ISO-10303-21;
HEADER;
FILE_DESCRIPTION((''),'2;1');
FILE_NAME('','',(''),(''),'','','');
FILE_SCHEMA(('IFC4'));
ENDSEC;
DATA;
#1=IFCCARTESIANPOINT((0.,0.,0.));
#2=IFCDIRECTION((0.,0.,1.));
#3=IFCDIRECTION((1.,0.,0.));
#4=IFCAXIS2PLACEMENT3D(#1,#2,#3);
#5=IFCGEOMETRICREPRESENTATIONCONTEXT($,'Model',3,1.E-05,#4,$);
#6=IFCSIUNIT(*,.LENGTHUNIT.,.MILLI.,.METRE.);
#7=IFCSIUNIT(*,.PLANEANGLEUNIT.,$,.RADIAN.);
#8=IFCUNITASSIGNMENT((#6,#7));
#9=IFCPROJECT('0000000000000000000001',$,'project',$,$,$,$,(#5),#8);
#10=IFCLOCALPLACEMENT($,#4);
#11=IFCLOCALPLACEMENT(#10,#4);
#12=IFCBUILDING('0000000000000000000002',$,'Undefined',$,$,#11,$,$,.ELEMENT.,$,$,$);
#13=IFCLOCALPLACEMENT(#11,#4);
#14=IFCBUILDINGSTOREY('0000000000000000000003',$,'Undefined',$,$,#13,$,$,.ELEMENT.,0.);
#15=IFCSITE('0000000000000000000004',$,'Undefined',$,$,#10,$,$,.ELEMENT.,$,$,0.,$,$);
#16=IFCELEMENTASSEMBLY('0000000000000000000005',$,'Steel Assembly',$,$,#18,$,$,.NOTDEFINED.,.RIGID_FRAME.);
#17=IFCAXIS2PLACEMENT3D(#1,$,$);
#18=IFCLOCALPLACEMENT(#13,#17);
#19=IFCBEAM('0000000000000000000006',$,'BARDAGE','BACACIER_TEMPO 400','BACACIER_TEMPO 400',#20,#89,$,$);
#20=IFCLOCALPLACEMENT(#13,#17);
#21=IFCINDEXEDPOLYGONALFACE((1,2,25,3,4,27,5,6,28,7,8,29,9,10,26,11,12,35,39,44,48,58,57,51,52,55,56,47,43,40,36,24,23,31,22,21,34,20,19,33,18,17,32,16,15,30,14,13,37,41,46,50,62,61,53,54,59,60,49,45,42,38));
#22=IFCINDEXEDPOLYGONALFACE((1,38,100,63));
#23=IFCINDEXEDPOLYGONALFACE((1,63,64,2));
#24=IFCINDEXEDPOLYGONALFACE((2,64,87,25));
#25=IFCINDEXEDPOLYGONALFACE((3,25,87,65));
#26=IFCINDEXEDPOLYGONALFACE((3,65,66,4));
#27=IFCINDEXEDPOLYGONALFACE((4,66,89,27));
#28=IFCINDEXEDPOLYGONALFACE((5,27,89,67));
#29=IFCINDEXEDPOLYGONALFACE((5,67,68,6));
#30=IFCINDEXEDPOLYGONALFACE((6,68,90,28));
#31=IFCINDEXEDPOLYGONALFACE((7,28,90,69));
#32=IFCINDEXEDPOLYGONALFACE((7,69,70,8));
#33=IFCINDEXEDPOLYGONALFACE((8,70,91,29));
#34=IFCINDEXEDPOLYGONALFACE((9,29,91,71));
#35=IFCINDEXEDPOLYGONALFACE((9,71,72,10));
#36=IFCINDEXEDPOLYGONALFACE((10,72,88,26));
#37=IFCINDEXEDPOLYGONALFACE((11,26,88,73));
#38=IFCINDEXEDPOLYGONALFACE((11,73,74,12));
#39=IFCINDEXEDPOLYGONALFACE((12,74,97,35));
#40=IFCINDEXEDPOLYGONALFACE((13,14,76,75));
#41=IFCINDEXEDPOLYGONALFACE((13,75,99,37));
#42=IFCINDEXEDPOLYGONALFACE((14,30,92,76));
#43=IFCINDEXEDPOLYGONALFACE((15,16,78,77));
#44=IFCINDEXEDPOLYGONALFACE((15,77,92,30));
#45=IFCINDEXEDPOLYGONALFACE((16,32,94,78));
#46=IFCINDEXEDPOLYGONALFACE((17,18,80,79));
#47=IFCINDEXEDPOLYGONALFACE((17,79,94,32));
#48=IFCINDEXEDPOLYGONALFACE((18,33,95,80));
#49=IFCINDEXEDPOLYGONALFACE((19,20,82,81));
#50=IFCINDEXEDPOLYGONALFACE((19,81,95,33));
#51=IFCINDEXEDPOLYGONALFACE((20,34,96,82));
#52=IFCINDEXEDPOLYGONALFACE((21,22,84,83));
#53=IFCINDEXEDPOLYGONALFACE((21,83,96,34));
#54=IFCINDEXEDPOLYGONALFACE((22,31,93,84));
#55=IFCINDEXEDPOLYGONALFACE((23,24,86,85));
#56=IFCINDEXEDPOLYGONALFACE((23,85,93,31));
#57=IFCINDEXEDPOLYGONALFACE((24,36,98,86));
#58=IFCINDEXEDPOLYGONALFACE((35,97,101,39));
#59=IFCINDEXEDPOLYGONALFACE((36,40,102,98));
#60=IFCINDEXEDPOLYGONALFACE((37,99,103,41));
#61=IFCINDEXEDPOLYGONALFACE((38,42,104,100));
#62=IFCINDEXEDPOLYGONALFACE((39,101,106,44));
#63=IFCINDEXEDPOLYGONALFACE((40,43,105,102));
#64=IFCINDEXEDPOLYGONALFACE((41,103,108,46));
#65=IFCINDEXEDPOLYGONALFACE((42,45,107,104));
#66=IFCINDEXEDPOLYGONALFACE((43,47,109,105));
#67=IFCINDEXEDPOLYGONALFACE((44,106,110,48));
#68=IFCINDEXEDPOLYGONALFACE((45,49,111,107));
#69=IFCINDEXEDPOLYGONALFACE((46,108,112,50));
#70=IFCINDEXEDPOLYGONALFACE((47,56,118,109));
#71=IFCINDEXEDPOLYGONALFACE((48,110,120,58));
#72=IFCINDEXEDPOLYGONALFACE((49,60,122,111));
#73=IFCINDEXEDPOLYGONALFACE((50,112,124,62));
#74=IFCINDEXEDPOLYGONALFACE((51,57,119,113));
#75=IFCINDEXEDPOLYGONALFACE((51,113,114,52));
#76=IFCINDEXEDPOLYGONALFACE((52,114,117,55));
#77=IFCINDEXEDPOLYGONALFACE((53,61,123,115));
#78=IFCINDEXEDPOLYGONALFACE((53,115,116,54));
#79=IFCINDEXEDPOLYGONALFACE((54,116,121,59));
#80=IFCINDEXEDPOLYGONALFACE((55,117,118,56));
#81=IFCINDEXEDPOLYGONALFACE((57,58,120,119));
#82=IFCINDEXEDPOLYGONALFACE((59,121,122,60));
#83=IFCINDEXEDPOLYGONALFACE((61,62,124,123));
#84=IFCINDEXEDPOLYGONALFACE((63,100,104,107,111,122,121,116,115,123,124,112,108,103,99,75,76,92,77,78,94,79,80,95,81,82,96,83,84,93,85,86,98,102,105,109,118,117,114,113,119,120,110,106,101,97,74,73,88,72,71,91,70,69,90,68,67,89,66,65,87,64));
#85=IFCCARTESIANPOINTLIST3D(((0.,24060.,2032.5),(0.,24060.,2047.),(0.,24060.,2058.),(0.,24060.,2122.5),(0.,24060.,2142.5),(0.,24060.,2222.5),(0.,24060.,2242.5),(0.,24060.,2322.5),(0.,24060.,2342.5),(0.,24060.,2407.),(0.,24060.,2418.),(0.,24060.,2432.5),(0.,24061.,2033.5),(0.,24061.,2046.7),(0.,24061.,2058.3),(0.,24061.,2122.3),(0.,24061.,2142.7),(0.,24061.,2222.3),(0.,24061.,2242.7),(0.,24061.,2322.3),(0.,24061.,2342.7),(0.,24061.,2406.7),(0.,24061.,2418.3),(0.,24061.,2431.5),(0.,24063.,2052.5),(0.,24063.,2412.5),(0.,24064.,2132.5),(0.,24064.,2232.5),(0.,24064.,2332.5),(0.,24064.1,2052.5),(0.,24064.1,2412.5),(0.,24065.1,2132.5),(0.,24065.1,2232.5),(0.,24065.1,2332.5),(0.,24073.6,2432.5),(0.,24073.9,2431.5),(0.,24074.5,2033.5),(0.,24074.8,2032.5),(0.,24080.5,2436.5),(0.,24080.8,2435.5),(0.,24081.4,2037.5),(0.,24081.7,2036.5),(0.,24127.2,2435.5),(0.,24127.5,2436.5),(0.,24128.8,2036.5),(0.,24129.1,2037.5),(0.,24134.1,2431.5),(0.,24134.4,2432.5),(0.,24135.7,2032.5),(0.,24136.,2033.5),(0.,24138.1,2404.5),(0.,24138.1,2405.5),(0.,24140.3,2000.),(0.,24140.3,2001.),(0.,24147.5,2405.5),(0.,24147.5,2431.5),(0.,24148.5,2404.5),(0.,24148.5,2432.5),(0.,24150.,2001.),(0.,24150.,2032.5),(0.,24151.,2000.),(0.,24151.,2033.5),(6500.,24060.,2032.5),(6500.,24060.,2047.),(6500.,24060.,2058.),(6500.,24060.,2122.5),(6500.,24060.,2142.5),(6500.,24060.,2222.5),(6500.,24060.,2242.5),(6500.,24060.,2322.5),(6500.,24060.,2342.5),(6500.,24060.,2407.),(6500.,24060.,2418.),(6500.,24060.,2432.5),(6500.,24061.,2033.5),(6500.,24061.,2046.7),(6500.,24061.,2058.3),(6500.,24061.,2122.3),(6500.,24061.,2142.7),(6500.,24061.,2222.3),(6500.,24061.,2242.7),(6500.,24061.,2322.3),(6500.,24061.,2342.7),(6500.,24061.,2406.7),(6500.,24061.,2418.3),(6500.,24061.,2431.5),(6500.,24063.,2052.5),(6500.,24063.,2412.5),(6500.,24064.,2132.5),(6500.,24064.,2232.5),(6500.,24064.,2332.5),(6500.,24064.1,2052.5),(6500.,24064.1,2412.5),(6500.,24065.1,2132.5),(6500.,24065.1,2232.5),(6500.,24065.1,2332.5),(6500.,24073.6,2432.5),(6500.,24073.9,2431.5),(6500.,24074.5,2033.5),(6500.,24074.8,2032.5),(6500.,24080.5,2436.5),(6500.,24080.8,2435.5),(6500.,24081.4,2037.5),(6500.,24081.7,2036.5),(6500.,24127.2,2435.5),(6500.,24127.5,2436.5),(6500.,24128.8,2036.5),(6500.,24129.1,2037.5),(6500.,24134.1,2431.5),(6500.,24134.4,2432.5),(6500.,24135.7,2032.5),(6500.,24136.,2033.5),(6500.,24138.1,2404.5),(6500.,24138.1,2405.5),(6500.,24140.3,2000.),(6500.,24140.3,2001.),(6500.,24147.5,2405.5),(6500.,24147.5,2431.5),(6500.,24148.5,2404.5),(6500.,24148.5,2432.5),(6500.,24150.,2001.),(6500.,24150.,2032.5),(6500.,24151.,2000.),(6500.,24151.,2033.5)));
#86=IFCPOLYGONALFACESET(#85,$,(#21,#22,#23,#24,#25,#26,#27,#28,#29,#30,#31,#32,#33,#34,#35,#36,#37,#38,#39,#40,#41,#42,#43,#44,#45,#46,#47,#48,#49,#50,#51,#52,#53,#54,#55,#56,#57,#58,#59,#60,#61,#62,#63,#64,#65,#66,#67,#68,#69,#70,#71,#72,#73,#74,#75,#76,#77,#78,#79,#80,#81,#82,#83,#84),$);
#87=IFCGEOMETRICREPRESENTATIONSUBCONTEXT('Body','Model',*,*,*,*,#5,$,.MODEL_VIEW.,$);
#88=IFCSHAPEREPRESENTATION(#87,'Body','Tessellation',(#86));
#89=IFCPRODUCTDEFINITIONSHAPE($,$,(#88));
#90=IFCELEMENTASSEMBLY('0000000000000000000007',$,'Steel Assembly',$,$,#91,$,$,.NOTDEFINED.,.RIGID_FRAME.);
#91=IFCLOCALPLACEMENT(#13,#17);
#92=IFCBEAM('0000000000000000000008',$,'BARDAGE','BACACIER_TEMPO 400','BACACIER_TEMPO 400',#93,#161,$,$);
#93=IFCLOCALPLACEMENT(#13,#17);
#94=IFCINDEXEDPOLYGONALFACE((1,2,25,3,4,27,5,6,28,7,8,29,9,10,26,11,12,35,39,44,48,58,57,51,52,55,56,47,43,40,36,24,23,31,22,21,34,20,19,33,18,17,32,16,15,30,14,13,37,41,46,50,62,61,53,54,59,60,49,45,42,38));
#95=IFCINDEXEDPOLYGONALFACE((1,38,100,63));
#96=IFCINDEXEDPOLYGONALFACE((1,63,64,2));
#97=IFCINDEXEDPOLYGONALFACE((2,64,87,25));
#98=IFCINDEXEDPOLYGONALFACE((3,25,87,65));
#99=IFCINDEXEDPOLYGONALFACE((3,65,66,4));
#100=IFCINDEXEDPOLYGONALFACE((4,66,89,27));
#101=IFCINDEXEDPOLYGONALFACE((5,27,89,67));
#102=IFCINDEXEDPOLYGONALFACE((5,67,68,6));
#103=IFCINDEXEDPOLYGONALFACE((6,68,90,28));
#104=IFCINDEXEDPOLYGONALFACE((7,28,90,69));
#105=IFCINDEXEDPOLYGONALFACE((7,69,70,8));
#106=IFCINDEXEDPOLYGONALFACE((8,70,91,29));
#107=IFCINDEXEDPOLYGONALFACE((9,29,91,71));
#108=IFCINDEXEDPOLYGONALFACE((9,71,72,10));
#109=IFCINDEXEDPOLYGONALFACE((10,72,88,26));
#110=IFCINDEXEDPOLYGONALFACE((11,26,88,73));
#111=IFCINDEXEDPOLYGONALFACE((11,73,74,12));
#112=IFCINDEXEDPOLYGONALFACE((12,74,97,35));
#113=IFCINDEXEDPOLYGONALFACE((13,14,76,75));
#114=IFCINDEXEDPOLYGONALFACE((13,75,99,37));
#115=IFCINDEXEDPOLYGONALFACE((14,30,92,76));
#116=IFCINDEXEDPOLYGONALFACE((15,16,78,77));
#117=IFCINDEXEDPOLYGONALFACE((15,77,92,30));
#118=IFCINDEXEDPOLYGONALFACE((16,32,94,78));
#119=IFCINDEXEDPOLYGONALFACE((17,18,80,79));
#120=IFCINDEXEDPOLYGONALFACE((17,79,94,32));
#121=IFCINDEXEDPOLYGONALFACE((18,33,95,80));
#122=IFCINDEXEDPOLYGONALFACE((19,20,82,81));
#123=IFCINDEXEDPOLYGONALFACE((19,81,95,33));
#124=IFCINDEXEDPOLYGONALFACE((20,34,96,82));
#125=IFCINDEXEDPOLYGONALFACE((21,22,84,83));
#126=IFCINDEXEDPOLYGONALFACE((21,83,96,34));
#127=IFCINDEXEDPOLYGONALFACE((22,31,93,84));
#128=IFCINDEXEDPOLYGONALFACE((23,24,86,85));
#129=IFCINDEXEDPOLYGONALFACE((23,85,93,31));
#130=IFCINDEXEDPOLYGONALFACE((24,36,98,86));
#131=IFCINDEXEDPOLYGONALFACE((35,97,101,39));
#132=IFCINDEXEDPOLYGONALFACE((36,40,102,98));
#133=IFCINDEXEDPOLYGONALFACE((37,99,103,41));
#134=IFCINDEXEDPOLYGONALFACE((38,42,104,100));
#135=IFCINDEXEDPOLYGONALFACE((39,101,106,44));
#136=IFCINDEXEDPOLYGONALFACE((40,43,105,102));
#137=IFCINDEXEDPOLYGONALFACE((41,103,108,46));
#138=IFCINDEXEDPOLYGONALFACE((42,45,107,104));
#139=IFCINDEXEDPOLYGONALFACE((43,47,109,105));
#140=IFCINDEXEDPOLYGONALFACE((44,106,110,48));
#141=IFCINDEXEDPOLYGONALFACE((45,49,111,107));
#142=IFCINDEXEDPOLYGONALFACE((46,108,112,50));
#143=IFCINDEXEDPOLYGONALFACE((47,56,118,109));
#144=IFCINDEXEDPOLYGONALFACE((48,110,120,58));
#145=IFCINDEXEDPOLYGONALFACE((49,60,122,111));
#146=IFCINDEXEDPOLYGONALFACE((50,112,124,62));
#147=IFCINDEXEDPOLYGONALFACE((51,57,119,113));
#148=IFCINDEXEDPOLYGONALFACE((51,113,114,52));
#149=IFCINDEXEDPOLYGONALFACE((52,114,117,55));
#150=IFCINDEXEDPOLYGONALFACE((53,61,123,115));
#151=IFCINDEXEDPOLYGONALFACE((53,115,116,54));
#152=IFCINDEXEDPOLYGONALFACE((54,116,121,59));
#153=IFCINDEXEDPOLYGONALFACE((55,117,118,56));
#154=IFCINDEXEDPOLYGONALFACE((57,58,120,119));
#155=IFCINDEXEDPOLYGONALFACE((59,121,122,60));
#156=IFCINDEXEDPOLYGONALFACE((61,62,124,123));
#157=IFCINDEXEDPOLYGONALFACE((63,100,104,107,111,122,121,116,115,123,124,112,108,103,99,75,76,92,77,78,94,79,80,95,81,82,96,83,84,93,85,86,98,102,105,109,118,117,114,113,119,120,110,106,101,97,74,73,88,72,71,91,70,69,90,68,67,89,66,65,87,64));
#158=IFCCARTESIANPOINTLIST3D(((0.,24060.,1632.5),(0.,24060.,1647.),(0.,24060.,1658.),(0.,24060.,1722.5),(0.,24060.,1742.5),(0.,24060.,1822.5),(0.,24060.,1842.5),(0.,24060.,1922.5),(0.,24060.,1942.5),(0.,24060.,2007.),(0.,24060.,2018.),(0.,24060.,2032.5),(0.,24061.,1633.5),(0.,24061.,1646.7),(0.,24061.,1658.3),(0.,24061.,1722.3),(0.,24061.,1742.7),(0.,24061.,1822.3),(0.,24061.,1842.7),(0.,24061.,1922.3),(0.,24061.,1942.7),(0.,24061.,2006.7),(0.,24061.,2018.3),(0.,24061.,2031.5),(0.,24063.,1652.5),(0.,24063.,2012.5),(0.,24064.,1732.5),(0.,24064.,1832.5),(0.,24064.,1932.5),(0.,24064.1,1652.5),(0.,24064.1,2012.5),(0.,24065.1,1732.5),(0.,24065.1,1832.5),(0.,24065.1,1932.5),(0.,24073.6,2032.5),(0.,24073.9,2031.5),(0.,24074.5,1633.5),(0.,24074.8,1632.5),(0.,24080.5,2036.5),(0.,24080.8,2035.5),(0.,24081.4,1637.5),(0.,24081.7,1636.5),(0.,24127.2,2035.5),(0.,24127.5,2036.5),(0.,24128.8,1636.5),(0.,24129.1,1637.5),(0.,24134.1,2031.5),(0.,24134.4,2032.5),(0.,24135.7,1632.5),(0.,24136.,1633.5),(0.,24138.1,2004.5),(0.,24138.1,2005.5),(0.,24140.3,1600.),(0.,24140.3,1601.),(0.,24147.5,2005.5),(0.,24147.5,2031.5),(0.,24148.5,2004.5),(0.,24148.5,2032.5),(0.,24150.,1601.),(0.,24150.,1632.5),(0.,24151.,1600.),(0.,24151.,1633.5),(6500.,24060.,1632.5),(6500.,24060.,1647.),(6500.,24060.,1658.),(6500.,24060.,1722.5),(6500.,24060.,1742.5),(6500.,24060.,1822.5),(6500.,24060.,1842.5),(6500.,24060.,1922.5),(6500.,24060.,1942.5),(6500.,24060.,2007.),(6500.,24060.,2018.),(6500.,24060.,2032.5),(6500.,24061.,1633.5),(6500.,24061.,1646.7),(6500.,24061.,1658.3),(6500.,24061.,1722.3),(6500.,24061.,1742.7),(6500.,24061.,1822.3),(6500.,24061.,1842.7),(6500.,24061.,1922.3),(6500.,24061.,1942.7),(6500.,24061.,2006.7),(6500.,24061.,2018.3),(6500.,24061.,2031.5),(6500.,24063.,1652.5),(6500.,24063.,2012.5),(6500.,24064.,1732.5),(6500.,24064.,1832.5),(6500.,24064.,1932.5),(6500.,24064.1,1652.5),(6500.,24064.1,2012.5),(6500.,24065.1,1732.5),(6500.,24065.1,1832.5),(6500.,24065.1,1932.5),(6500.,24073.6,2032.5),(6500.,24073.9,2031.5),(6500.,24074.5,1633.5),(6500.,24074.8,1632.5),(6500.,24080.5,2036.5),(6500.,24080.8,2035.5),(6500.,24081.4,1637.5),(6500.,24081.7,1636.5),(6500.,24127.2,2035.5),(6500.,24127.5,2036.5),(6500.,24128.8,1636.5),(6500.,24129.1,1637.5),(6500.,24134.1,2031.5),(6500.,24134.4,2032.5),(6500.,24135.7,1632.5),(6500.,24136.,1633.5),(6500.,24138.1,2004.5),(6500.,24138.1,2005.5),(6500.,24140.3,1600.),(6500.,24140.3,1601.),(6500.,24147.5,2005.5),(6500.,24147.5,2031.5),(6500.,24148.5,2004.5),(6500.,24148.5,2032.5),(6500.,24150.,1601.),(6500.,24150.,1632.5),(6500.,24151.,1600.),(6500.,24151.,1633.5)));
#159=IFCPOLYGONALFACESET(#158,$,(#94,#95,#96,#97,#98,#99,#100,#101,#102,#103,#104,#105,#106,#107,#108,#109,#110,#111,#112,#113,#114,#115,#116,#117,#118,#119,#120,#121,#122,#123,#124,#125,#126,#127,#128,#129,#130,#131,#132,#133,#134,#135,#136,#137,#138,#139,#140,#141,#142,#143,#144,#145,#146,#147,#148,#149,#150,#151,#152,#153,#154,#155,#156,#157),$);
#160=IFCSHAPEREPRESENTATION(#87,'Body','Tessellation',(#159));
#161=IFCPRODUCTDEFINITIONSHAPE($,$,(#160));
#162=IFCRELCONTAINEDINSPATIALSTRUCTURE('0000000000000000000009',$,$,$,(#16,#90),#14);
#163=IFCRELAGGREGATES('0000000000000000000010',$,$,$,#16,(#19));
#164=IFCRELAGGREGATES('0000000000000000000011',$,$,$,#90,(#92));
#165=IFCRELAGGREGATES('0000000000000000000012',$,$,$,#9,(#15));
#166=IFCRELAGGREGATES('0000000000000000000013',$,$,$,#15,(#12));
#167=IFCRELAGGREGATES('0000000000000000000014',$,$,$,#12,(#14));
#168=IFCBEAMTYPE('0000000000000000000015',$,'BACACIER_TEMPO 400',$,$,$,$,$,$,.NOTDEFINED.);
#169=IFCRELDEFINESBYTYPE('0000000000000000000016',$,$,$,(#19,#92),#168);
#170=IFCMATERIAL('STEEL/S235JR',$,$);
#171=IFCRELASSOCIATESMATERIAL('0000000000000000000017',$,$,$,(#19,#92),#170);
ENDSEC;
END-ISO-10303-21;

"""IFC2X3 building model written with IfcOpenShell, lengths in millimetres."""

from ifc_helpers import new_model, si_unit, frame, origin_with_axes, place, context, subcontext, project, spatial, polyline, outline, extrude, material, type_object, element, aggregate, save


model = new_model("IFC2X3")

# Units and contexts
model_context = context("Model", 3, precision=1e-05, world=origin_with_axes())
body_context = subcontext(model_context, "Body", "Model", "MODEL_VIEW")
ifc_project = project(units=[si_unit("LENGTHUNIT", "METRE", prefix="MILLI"), si_unit("PLANEANGLEUNIT", "RADIAN")], contexts=[model_context])

# Site, building, storey
site_placement = place(None, origin_with_axes())
site = spatial("IfcSite", under=ifc_project, at=site_placement, Name="Undefined", CompositionType="ELEMENT", RefElevation=0.0)
building_placement = place(site_placement, origin_with_axes())
building = spatial("IfcBuilding", under=site, at=building_placement, Name="Undefined", CompositionType="ELEMENT")
storey_placement = place(building_placement, origin_with_axes())
storey = spatial("IfcBuildingStorey", under=building, at=storey_placement, Name="Undefined", CompositionType="ELEMENT", Elevation=0.0)

# Element assemblies, beams
ifc_material_1 = material(Name="STEEL/S235JR")
beam_type_1 = type_object("IfcBeamType", Name="BACACIER_TEMPO 400", PredefinedType="NOTDEFINED")
assembly_1_placement = place(storey_placement, origin_with_axes())
assembly_1 = element("IfcElementAssembly", 1, at=assembly_1_placement, inside=storey, Name="Steel Assembly", AssemblyPlace="NOTDEFINED", PredefinedType="RIGID_FRAME")
beam_1_placement = place(assembly_1_placement, frame((0.0, 24105.5, 2218.2), z_axis=(0.0, 1.0, 0.0), x_axis=(1.0, 0.0, 0.0)))
beam_1 = element("IfcBeam", 2, at=beam_1_placement, type_object=beam_type_1, material=ifc_material_1, Name="BARDAGE", Description="BACACIER_TEMPO 400", ObjectType="BACACIER_TEMPO 400", context=body_context, shape_type="SweptSolid", body=[
    extrude(outline(polyline([(218.2, -25.0), (214.2, -31.9), (214.2, -45.5), (199.8, -45.5), (194.2, -42.5), (188.8, -45.5), (124.2, -45.5), (114.2, -41.5), (104.2, -45.5), (24.2, -45.5), (14.2, -41.5), (4.2, -45.5), (-75.8, -45.5), (-85.8, -41.5), (-95.8, -45.5), (-160.2, -45.5), (-165.8, -42.5), (-171.2, -45.5), (-185.8, -45.5), (-185.8, -30.7), (-181.8, -23.8), (-181.8, 23.3), (-185.8, 30.2), (-185.8, 44.5), (-217.2, 44.5), (-217.2, 34.8), (-218.2, 34.8), (-218.2, 45.5), (-184.8, 45.5), (-184.8, 30.5), (-180.8, 23.6), (-180.8, -24.1), (-184.8, -31.0), (-184.8, -44.5), (-171.5, -44.5), (-165.8, -41.4), (-160.0, -44.5), (-95.9, -44.5), (-85.8, -40.4), (-75.6, -44.5), (4.1, -44.5), (14.2, -40.4), (24.4, -44.5), (104.1, -44.5), (114.2, -40.4), (124.4, -44.5), (188.5, -44.5), (194.2, -41.4), (200.0, -44.5), (213.2, -44.5), (213.2, -31.6), (217.2, -24.7), (217.2, 21.7), (213.2, 28.6), (213.2, 42.0), (187.2, 42.0), (187.2, 32.5), (186.2, 32.5), (186.2, 43.0), (214.2, 43.0), (214.2, 28.9), (218.2, 22.0), (218.2, -25.0)])), frame((6500.0, 0.0, 0.0), z_axis=(-1.0, 0.0, 0.0), x_axis=(0.0, -1.0, 0.0)), (0.0, 0.0, 1.0), 6500.0),
])
aggregate(assembly_1, [beam_1])
assembly_2_placement = place(storey_placement, origin_with_axes())
assembly_2 = element("IfcElementAssembly", 3, at=assembly_2_placement, inside=storey, Name="Steel Assembly", AssemblyPlace="NOTDEFINED", PredefinedType="RIGID_FRAME")
beam_2_placement = place(assembly_2_placement, frame((0.0, 24105.5, 1818.2), z_axis=(0.0, 1.0, 0.0), x_axis=(1.0, 0.0, 0.0)))
beam_2 = element("IfcBeam", 4, at=beam_2_placement, type_object=beam_type_1, material=ifc_material_1, Name="BARDAGE", Description="BACACIER_TEMPO 400", ObjectType="BACACIER_TEMPO 400", context=body_context, shape_type="SweptSolid", body=[
    extrude(outline(polyline([(218.2, -25.0), (214.2, -31.9), (214.2, -45.5), (199.8, -45.5), (194.2, -42.5), (188.8, -45.5), (124.2, -45.5), (114.2, -41.5), (104.2, -45.5), (24.2, -45.5), (14.2, -41.5), (4.2, -45.5), (-75.8, -45.5), (-85.8, -41.5), (-95.8, -45.5), (-160.2, -45.5), (-165.8, -42.5), (-171.2, -45.5), (-185.8, -45.5), (-185.8, -30.7), (-181.8, -23.8), (-181.8, 23.3), (-185.8, 30.2), (-185.8, 44.5), (-217.2, 44.5), (-217.2, 34.8), (-218.2, 34.8), (-218.2, 45.5), (-184.8, 45.5), (-184.8, 30.5), (-180.8, 23.6), (-180.8, -24.1), (-184.8, -31.0), (-184.8, -44.5), (-171.5, -44.5), (-165.8, -41.4), (-160.0, -44.5), (-95.9, -44.5), (-85.8, -40.4), (-75.6, -44.5), (4.1, -44.5), (14.2, -40.4), (24.4, -44.5), (104.1, -44.5), (114.2, -40.4), (124.4, -44.5), (188.5, -44.5), (194.2, -41.4), (200.0, -44.5), (213.2, -44.5), (213.2, -31.6), (217.2, -24.7), (217.2, 21.7), (213.2, 28.6), (213.2, 42.0), (187.2, 42.0), (187.2, 32.5), (186.2, 32.5), (186.2, 43.0), (214.2, 43.0), (214.2, 28.9), (218.2, 22.0), (218.2, -25.0)])), frame((6500.0, 0.0, 0.0), z_axis=(-1.0, 0.0, 0.0), x_axis=(0.0, -1.0, 0.0)), (0.0, 0.0, 1.0), 6500.0),
])
aggregate(assembly_2, [beam_2])

save(model, "model.ifc")
